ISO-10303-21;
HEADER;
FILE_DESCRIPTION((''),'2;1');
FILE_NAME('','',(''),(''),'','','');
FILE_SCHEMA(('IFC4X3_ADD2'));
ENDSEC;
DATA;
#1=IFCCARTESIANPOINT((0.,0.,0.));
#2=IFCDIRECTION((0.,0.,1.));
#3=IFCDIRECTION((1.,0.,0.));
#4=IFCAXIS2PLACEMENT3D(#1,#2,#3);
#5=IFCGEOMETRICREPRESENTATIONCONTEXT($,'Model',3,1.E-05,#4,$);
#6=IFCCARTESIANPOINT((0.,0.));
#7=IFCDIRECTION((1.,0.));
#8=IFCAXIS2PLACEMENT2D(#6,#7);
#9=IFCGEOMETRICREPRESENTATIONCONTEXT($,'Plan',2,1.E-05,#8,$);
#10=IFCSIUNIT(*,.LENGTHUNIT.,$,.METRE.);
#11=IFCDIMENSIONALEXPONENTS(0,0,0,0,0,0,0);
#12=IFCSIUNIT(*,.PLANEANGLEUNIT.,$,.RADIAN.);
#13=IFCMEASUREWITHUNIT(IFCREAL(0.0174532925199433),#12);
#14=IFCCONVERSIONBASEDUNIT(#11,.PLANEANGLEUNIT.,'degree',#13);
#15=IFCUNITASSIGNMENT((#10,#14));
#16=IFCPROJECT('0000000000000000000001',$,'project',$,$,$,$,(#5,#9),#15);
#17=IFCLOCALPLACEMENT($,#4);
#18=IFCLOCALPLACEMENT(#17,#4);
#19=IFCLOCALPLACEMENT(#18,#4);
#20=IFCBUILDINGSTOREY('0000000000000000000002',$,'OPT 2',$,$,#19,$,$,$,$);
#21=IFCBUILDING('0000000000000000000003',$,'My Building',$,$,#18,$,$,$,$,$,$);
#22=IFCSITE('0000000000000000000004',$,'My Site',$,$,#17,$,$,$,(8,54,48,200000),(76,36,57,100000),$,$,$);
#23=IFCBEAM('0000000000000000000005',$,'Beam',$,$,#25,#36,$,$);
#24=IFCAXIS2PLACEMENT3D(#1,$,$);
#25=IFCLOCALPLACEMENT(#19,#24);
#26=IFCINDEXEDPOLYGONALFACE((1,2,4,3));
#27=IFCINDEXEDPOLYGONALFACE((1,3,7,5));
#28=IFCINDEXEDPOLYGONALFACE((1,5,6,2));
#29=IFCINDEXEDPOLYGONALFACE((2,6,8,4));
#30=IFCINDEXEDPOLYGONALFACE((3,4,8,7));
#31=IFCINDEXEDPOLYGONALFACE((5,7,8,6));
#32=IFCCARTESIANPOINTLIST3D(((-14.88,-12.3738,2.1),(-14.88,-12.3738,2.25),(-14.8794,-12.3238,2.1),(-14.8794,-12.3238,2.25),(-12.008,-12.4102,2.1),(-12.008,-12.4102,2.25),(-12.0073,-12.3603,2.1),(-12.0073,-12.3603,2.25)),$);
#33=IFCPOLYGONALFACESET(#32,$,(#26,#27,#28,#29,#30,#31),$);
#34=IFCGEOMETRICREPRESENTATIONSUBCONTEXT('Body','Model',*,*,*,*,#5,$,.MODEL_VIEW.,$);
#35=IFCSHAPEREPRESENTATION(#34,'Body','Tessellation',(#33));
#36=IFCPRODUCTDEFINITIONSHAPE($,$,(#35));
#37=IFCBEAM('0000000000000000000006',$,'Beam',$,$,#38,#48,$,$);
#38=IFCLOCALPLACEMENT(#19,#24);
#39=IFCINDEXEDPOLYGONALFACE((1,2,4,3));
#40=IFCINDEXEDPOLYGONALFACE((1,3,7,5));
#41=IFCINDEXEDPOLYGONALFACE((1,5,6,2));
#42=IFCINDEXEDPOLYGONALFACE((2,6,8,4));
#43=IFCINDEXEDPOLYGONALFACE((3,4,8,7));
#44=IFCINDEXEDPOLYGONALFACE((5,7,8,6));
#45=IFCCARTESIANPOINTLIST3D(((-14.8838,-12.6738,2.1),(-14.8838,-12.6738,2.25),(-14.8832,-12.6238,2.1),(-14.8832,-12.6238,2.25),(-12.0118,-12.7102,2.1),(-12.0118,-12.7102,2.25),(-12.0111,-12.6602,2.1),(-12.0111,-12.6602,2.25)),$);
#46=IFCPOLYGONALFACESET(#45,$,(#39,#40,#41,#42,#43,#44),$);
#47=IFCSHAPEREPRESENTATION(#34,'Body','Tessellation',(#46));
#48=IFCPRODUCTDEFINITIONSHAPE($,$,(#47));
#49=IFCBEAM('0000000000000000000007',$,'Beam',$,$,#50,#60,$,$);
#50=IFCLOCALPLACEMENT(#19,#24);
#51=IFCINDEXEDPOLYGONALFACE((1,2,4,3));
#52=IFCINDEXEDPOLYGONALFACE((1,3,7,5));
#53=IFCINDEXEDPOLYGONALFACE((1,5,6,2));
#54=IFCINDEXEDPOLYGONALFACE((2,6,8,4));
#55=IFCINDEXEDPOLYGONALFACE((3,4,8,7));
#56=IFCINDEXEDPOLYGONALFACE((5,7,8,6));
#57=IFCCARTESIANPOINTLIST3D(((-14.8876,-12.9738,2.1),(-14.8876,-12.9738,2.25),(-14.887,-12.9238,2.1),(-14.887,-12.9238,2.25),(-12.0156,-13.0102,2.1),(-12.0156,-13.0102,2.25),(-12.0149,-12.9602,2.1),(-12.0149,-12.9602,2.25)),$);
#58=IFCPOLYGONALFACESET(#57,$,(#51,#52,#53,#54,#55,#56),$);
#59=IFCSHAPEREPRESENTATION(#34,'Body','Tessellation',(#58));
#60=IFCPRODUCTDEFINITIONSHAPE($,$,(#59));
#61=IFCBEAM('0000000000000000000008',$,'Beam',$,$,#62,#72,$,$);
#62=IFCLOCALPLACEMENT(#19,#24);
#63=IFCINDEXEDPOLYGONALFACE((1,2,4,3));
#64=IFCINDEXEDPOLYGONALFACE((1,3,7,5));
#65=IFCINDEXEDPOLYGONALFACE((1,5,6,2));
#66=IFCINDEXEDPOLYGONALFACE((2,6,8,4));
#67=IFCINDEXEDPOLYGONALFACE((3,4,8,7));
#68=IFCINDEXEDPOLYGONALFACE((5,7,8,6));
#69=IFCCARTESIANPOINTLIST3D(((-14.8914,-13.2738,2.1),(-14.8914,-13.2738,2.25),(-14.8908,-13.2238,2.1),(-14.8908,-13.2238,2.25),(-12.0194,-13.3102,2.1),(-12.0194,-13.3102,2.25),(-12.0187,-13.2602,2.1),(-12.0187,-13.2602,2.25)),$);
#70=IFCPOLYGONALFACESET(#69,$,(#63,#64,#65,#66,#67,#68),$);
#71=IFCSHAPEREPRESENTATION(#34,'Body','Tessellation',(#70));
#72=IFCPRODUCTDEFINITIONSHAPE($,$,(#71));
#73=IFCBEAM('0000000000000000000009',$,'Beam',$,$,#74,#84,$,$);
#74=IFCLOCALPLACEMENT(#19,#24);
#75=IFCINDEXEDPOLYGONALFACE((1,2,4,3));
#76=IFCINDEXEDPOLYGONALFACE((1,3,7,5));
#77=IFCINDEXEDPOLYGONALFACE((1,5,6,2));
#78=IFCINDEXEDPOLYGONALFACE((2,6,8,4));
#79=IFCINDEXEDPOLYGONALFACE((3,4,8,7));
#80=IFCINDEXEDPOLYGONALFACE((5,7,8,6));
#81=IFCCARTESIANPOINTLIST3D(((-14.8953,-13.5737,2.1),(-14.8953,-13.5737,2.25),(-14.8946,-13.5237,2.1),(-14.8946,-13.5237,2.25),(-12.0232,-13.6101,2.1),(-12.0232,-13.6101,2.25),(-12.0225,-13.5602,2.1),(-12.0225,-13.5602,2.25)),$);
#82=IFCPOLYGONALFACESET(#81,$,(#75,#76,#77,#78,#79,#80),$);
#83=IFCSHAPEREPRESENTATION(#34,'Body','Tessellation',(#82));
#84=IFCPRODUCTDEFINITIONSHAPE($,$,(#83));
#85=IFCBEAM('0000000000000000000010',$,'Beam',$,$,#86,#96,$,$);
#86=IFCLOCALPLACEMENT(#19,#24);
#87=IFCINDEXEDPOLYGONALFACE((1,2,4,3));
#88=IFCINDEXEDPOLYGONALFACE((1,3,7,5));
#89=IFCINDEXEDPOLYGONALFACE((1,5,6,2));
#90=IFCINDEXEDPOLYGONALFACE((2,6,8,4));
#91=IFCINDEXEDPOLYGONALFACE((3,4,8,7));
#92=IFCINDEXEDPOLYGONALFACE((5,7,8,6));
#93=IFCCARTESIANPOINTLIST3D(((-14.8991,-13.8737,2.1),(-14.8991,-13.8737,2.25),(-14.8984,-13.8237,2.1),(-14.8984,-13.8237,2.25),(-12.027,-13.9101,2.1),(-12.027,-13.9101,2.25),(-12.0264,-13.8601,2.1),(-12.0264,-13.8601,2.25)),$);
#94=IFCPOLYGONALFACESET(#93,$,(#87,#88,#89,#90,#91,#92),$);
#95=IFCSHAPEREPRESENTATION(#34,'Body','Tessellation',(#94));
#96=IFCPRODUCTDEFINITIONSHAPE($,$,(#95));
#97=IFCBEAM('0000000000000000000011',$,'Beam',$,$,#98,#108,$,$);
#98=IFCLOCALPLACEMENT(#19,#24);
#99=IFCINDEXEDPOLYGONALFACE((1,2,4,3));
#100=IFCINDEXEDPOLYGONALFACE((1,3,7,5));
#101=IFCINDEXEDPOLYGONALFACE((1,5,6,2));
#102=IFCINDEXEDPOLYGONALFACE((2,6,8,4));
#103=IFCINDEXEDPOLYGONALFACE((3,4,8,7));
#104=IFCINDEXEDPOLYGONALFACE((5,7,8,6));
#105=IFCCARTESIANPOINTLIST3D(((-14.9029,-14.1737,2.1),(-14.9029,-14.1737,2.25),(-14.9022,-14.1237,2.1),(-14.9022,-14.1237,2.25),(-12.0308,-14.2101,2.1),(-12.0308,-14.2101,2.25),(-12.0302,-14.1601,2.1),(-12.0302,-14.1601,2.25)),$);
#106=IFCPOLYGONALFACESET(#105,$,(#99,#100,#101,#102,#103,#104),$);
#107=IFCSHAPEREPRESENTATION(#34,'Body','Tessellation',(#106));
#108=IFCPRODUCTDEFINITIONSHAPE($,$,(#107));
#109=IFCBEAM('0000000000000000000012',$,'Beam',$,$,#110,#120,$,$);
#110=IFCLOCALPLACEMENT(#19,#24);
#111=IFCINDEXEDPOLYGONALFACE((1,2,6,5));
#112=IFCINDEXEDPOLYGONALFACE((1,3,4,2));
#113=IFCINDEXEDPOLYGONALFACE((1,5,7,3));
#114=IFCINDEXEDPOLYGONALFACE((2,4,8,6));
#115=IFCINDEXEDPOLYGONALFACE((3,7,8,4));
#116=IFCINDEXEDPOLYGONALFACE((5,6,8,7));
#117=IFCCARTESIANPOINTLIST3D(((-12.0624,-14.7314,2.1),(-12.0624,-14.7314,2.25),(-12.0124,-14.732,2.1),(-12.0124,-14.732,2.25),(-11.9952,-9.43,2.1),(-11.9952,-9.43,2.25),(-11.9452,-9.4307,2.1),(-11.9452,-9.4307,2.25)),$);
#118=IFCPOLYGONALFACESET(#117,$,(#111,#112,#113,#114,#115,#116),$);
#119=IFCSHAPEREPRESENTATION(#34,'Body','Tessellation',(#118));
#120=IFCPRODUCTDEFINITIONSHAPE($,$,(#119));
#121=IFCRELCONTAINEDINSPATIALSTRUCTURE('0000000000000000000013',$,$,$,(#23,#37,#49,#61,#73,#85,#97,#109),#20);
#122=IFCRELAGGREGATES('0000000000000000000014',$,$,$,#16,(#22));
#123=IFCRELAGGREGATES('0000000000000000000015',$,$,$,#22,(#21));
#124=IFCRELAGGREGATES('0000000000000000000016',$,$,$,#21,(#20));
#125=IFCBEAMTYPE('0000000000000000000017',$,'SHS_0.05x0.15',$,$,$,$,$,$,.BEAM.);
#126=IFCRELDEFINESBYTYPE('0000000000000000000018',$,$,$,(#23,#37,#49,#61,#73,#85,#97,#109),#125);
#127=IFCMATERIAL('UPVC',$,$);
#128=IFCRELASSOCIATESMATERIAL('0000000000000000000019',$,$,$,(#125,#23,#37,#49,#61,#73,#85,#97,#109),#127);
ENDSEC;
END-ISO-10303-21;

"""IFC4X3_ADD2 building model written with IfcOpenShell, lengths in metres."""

from ifc_helpers import new_model, entity, si_unit, converted_unit, frame, origin_with_axes, origin_2d_with_axis, place, context, subcontext, project, spatial, rectangle, extrude, material, material_profile, profile_set, profile_usage, type_object, element, save


model = new_model("IFC4X3_ADD2")

# Units and contexts
model_context = context("Model", 3, precision=1e-05, world=origin_with_axes())
plan_context = context("Plan", 2, precision=1e-05, world=origin_2d_with_axis())
body_context = subcontext(model_context, "Body", "Model", "MODEL_VIEW")
ifc_project = project(units=[si_unit("LENGTHUNIT", "METRE"), converted_unit("PLANEANGLEUNIT", "degree", entity("IfcReal", 0.0174532925199433), si_unit("PLANEANGLEUNIT", "RADIAN"), dimensions=[0, 0, 0, 0, 0, 0, 0])], contexts=[model_context, plan_context])

# Site, building, storey
site_placement = place(None, origin_with_axes())
site = spatial("IfcSite", under=ifc_project, at=site_placement, Name="My Site", RefLatitude=(8, 54, 48, 200000), RefLongitude=(76, 36, 57, 100000))
building_placement = place(site_placement, origin_with_axes())
building = spatial("IfcBuilding", under=site, at=building_placement, Name="My Building")
storey_placement = place(building_placement, origin_with_axes())
storey = spatial("IfcBuildingStorey", under=building, at=storey_placement, Name="OPT 2")

# Shared definitions
ifc_material_1 = material(Name="UPVC")

# Beams
ifc_material_profile_1 = material_profile(ifc_material_1, rectangle(XDim=0.05, YDim=0.15))
ifc_profile_set_1 = profile_set([ifc_material_profile_1])
beam_type = type_object("IfcBeamType", Name="SHS_0.05x0.15", PredefinedType="BEAM", material=ifc_profile_set_1)
ifc_profile_usage_1 = profile_usage(ifc_profile_set_1, cardinal=5)
beam_1_placement = place(storey_placement, frame((-12.0077, -12.3852, 2.175), z_axis=(-0.99992, 0.012677, 0.000001), x_axis=(-0.012677, -0.99992, 0.0)))
element("IfcBeam", 1, at=beam_1_placement, inside=storey, type_object=beam_type, material=ifc_profile_usage_1, Name="Beam", context=body_context, shape_type="SweptSolid", body=[
    extrude(rectangle(XDim=0.05, YDim=0.15), origin_with_axes(), (0.0, 0.0, 1.0), 2.8723),
])
ifc_profile_usage_2 = profile_usage(ifc_profile_set_1, cardinal=5)
beam_2_placement = place(storey_placement, frame((-12.0115, -12.6852, 2.175), z_axis=(-0.99992, 0.012677, 0.000001), x_axis=(-0.012677, -0.99992, 0.0)))
element("IfcBeam", 2, at=beam_2_placement, inside=storey, type_object=beam_type, material=ifc_profile_usage_2, Name="Beam", context=body_context, shape_type="SweptSolid", body=[
    extrude(rectangle(XDim=0.05, YDim=0.15), origin_with_axes(), (0.0, 0.0, 1.0), 2.8723),
])
ifc_profile_usage_3 = profile_usage(ifc_profile_set_1, cardinal=5)
beam_3_placement = place(storey_placement, frame((-12.0153, -12.9852, 2.175), z_axis=(-0.99992, 0.012677, 0.000001), x_axis=(-0.012677, -0.99992, 0.0)))
element("IfcBeam", 3, at=beam_3_placement, inside=storey, type_object=beam_type, material=ifc_profile_usage_3, Name="Beam", context=body_context, shape_type="SweptSolid", body=[
    extrude(rectangle(XDim=0.05, YDim=0.15), origin_with_axes(), (0.0, 0.0, 1.0), 2.8723),
])
ifc_profile_usage_4 = profile_usage(ifc_profile_set_1, cardinal=5)
beam_4_placement = place(storey_placement, frame((-12.0191, -13.2852, 2.175), z_axis=(-0.99992, 0.012677, 0.000001), x_axis=(-0.012677, -0.99992, 0.0)))
element("IfcBeam", 4, at=beam_4_placement, inside=storey, type_object=beam_type, material=ifc_profile_usage_4, Name="Beam", context=body_context, shape_type="SweptSolid", body=[
    extrude(rectangle(XDim=0.05, YDim=0.15), origin_with_axes(), (0.0, 0.0, 1.0), 2.8723),
])
ifc_profile_usage_5 = profile_usage(ifc_profile_set_1, cardinal=5)
beam_5_placement = place(storey_placement, frame((-12.0229, -13.5852, 2.175), z_axis=(-0.99992, 0.012677, 0.000001), x_axis=(-0.012677, -0.99992, 0.0)))
element("IfcBeam", 5, at=beam_5_placement, inside=storey, type_object=beam_type, material=ifc_profile_usage_5, Name="Beam", context=body_context, shape_type="SweptSolid", body=[
    extrude(rectangle(XDim=0.05, YDim=0.15), origin_with_axes(), (0.0, 0.0, 1.0), 2.8723),
])
ifc_profile_usage_6 = profile_usage(ifc_profile_set_1, cardinal=5)
beam_6_placement = place(storey_placement, frame((-12.0267, -13.8851, 2.175), z_axis=(-0.99992, 0.012677, 0.000001), x_axis=(-0.012677, -0.99992, 0.0)))
element("IfcBeam", 6, at=beam_6_placement, inside=storey, type_object=beam_type, material=ifc_profile_usage_6, Name="Beam", context=body_context, shape_type="SweptSolid", body=[
    extrude(rectangle(XDim=0.05, YDim=0.15), origin_with_axes(), (0.0, 0.0, 1.0), 2.8723),
])
ifc_profile_usage_7 = profile_usage(ifc_profile_set_1, cardinal=5)
beam_7_placement = place(storey_placement, frame((-12.0305, -14.1851, 2.175), z_axis=(-0.99992, 0.012677, 0.000001), x_axis=(-0.012677, -0.99992, 0.0)))
element("IfcBeam", 7, at=beam_7_placement, inside=storey, type_object=beam_type, material=ifc_profile_usage_7, Name="Beam", context=body_context, shape_type="SweptSolid", body=[
    extrude(rectangle(XDim=0.05, YDim=0.15), origin_with_axes(), (0.0, 0.0, 1.0), 2.8723),
])
ifc_profile_usage_8 = profile_usage(ifc_profile_set_1, cardinal=5)
beam_8_placement = place(storey_placement, frame((-12.0374, -14.7317, 2.175), z_axis=(0.012677, 0.99992, 0.0), x_axis=(-0.99992, 0.012677, 0.0)))
element("IfcBeam", 8, at=beam_8_placement, inside=storey, type_object=beam_type, material=ifc_profile_usage_8, Name="Beam", context=body_context, shape_type="SweptSolid", body=[
    extrude(rectangle(XDim=0.05, YDim=0.15), origin_with_axes(), (0.0, 0.0, 1.0), 5.3018),
])

save(model, "model.ifc")
